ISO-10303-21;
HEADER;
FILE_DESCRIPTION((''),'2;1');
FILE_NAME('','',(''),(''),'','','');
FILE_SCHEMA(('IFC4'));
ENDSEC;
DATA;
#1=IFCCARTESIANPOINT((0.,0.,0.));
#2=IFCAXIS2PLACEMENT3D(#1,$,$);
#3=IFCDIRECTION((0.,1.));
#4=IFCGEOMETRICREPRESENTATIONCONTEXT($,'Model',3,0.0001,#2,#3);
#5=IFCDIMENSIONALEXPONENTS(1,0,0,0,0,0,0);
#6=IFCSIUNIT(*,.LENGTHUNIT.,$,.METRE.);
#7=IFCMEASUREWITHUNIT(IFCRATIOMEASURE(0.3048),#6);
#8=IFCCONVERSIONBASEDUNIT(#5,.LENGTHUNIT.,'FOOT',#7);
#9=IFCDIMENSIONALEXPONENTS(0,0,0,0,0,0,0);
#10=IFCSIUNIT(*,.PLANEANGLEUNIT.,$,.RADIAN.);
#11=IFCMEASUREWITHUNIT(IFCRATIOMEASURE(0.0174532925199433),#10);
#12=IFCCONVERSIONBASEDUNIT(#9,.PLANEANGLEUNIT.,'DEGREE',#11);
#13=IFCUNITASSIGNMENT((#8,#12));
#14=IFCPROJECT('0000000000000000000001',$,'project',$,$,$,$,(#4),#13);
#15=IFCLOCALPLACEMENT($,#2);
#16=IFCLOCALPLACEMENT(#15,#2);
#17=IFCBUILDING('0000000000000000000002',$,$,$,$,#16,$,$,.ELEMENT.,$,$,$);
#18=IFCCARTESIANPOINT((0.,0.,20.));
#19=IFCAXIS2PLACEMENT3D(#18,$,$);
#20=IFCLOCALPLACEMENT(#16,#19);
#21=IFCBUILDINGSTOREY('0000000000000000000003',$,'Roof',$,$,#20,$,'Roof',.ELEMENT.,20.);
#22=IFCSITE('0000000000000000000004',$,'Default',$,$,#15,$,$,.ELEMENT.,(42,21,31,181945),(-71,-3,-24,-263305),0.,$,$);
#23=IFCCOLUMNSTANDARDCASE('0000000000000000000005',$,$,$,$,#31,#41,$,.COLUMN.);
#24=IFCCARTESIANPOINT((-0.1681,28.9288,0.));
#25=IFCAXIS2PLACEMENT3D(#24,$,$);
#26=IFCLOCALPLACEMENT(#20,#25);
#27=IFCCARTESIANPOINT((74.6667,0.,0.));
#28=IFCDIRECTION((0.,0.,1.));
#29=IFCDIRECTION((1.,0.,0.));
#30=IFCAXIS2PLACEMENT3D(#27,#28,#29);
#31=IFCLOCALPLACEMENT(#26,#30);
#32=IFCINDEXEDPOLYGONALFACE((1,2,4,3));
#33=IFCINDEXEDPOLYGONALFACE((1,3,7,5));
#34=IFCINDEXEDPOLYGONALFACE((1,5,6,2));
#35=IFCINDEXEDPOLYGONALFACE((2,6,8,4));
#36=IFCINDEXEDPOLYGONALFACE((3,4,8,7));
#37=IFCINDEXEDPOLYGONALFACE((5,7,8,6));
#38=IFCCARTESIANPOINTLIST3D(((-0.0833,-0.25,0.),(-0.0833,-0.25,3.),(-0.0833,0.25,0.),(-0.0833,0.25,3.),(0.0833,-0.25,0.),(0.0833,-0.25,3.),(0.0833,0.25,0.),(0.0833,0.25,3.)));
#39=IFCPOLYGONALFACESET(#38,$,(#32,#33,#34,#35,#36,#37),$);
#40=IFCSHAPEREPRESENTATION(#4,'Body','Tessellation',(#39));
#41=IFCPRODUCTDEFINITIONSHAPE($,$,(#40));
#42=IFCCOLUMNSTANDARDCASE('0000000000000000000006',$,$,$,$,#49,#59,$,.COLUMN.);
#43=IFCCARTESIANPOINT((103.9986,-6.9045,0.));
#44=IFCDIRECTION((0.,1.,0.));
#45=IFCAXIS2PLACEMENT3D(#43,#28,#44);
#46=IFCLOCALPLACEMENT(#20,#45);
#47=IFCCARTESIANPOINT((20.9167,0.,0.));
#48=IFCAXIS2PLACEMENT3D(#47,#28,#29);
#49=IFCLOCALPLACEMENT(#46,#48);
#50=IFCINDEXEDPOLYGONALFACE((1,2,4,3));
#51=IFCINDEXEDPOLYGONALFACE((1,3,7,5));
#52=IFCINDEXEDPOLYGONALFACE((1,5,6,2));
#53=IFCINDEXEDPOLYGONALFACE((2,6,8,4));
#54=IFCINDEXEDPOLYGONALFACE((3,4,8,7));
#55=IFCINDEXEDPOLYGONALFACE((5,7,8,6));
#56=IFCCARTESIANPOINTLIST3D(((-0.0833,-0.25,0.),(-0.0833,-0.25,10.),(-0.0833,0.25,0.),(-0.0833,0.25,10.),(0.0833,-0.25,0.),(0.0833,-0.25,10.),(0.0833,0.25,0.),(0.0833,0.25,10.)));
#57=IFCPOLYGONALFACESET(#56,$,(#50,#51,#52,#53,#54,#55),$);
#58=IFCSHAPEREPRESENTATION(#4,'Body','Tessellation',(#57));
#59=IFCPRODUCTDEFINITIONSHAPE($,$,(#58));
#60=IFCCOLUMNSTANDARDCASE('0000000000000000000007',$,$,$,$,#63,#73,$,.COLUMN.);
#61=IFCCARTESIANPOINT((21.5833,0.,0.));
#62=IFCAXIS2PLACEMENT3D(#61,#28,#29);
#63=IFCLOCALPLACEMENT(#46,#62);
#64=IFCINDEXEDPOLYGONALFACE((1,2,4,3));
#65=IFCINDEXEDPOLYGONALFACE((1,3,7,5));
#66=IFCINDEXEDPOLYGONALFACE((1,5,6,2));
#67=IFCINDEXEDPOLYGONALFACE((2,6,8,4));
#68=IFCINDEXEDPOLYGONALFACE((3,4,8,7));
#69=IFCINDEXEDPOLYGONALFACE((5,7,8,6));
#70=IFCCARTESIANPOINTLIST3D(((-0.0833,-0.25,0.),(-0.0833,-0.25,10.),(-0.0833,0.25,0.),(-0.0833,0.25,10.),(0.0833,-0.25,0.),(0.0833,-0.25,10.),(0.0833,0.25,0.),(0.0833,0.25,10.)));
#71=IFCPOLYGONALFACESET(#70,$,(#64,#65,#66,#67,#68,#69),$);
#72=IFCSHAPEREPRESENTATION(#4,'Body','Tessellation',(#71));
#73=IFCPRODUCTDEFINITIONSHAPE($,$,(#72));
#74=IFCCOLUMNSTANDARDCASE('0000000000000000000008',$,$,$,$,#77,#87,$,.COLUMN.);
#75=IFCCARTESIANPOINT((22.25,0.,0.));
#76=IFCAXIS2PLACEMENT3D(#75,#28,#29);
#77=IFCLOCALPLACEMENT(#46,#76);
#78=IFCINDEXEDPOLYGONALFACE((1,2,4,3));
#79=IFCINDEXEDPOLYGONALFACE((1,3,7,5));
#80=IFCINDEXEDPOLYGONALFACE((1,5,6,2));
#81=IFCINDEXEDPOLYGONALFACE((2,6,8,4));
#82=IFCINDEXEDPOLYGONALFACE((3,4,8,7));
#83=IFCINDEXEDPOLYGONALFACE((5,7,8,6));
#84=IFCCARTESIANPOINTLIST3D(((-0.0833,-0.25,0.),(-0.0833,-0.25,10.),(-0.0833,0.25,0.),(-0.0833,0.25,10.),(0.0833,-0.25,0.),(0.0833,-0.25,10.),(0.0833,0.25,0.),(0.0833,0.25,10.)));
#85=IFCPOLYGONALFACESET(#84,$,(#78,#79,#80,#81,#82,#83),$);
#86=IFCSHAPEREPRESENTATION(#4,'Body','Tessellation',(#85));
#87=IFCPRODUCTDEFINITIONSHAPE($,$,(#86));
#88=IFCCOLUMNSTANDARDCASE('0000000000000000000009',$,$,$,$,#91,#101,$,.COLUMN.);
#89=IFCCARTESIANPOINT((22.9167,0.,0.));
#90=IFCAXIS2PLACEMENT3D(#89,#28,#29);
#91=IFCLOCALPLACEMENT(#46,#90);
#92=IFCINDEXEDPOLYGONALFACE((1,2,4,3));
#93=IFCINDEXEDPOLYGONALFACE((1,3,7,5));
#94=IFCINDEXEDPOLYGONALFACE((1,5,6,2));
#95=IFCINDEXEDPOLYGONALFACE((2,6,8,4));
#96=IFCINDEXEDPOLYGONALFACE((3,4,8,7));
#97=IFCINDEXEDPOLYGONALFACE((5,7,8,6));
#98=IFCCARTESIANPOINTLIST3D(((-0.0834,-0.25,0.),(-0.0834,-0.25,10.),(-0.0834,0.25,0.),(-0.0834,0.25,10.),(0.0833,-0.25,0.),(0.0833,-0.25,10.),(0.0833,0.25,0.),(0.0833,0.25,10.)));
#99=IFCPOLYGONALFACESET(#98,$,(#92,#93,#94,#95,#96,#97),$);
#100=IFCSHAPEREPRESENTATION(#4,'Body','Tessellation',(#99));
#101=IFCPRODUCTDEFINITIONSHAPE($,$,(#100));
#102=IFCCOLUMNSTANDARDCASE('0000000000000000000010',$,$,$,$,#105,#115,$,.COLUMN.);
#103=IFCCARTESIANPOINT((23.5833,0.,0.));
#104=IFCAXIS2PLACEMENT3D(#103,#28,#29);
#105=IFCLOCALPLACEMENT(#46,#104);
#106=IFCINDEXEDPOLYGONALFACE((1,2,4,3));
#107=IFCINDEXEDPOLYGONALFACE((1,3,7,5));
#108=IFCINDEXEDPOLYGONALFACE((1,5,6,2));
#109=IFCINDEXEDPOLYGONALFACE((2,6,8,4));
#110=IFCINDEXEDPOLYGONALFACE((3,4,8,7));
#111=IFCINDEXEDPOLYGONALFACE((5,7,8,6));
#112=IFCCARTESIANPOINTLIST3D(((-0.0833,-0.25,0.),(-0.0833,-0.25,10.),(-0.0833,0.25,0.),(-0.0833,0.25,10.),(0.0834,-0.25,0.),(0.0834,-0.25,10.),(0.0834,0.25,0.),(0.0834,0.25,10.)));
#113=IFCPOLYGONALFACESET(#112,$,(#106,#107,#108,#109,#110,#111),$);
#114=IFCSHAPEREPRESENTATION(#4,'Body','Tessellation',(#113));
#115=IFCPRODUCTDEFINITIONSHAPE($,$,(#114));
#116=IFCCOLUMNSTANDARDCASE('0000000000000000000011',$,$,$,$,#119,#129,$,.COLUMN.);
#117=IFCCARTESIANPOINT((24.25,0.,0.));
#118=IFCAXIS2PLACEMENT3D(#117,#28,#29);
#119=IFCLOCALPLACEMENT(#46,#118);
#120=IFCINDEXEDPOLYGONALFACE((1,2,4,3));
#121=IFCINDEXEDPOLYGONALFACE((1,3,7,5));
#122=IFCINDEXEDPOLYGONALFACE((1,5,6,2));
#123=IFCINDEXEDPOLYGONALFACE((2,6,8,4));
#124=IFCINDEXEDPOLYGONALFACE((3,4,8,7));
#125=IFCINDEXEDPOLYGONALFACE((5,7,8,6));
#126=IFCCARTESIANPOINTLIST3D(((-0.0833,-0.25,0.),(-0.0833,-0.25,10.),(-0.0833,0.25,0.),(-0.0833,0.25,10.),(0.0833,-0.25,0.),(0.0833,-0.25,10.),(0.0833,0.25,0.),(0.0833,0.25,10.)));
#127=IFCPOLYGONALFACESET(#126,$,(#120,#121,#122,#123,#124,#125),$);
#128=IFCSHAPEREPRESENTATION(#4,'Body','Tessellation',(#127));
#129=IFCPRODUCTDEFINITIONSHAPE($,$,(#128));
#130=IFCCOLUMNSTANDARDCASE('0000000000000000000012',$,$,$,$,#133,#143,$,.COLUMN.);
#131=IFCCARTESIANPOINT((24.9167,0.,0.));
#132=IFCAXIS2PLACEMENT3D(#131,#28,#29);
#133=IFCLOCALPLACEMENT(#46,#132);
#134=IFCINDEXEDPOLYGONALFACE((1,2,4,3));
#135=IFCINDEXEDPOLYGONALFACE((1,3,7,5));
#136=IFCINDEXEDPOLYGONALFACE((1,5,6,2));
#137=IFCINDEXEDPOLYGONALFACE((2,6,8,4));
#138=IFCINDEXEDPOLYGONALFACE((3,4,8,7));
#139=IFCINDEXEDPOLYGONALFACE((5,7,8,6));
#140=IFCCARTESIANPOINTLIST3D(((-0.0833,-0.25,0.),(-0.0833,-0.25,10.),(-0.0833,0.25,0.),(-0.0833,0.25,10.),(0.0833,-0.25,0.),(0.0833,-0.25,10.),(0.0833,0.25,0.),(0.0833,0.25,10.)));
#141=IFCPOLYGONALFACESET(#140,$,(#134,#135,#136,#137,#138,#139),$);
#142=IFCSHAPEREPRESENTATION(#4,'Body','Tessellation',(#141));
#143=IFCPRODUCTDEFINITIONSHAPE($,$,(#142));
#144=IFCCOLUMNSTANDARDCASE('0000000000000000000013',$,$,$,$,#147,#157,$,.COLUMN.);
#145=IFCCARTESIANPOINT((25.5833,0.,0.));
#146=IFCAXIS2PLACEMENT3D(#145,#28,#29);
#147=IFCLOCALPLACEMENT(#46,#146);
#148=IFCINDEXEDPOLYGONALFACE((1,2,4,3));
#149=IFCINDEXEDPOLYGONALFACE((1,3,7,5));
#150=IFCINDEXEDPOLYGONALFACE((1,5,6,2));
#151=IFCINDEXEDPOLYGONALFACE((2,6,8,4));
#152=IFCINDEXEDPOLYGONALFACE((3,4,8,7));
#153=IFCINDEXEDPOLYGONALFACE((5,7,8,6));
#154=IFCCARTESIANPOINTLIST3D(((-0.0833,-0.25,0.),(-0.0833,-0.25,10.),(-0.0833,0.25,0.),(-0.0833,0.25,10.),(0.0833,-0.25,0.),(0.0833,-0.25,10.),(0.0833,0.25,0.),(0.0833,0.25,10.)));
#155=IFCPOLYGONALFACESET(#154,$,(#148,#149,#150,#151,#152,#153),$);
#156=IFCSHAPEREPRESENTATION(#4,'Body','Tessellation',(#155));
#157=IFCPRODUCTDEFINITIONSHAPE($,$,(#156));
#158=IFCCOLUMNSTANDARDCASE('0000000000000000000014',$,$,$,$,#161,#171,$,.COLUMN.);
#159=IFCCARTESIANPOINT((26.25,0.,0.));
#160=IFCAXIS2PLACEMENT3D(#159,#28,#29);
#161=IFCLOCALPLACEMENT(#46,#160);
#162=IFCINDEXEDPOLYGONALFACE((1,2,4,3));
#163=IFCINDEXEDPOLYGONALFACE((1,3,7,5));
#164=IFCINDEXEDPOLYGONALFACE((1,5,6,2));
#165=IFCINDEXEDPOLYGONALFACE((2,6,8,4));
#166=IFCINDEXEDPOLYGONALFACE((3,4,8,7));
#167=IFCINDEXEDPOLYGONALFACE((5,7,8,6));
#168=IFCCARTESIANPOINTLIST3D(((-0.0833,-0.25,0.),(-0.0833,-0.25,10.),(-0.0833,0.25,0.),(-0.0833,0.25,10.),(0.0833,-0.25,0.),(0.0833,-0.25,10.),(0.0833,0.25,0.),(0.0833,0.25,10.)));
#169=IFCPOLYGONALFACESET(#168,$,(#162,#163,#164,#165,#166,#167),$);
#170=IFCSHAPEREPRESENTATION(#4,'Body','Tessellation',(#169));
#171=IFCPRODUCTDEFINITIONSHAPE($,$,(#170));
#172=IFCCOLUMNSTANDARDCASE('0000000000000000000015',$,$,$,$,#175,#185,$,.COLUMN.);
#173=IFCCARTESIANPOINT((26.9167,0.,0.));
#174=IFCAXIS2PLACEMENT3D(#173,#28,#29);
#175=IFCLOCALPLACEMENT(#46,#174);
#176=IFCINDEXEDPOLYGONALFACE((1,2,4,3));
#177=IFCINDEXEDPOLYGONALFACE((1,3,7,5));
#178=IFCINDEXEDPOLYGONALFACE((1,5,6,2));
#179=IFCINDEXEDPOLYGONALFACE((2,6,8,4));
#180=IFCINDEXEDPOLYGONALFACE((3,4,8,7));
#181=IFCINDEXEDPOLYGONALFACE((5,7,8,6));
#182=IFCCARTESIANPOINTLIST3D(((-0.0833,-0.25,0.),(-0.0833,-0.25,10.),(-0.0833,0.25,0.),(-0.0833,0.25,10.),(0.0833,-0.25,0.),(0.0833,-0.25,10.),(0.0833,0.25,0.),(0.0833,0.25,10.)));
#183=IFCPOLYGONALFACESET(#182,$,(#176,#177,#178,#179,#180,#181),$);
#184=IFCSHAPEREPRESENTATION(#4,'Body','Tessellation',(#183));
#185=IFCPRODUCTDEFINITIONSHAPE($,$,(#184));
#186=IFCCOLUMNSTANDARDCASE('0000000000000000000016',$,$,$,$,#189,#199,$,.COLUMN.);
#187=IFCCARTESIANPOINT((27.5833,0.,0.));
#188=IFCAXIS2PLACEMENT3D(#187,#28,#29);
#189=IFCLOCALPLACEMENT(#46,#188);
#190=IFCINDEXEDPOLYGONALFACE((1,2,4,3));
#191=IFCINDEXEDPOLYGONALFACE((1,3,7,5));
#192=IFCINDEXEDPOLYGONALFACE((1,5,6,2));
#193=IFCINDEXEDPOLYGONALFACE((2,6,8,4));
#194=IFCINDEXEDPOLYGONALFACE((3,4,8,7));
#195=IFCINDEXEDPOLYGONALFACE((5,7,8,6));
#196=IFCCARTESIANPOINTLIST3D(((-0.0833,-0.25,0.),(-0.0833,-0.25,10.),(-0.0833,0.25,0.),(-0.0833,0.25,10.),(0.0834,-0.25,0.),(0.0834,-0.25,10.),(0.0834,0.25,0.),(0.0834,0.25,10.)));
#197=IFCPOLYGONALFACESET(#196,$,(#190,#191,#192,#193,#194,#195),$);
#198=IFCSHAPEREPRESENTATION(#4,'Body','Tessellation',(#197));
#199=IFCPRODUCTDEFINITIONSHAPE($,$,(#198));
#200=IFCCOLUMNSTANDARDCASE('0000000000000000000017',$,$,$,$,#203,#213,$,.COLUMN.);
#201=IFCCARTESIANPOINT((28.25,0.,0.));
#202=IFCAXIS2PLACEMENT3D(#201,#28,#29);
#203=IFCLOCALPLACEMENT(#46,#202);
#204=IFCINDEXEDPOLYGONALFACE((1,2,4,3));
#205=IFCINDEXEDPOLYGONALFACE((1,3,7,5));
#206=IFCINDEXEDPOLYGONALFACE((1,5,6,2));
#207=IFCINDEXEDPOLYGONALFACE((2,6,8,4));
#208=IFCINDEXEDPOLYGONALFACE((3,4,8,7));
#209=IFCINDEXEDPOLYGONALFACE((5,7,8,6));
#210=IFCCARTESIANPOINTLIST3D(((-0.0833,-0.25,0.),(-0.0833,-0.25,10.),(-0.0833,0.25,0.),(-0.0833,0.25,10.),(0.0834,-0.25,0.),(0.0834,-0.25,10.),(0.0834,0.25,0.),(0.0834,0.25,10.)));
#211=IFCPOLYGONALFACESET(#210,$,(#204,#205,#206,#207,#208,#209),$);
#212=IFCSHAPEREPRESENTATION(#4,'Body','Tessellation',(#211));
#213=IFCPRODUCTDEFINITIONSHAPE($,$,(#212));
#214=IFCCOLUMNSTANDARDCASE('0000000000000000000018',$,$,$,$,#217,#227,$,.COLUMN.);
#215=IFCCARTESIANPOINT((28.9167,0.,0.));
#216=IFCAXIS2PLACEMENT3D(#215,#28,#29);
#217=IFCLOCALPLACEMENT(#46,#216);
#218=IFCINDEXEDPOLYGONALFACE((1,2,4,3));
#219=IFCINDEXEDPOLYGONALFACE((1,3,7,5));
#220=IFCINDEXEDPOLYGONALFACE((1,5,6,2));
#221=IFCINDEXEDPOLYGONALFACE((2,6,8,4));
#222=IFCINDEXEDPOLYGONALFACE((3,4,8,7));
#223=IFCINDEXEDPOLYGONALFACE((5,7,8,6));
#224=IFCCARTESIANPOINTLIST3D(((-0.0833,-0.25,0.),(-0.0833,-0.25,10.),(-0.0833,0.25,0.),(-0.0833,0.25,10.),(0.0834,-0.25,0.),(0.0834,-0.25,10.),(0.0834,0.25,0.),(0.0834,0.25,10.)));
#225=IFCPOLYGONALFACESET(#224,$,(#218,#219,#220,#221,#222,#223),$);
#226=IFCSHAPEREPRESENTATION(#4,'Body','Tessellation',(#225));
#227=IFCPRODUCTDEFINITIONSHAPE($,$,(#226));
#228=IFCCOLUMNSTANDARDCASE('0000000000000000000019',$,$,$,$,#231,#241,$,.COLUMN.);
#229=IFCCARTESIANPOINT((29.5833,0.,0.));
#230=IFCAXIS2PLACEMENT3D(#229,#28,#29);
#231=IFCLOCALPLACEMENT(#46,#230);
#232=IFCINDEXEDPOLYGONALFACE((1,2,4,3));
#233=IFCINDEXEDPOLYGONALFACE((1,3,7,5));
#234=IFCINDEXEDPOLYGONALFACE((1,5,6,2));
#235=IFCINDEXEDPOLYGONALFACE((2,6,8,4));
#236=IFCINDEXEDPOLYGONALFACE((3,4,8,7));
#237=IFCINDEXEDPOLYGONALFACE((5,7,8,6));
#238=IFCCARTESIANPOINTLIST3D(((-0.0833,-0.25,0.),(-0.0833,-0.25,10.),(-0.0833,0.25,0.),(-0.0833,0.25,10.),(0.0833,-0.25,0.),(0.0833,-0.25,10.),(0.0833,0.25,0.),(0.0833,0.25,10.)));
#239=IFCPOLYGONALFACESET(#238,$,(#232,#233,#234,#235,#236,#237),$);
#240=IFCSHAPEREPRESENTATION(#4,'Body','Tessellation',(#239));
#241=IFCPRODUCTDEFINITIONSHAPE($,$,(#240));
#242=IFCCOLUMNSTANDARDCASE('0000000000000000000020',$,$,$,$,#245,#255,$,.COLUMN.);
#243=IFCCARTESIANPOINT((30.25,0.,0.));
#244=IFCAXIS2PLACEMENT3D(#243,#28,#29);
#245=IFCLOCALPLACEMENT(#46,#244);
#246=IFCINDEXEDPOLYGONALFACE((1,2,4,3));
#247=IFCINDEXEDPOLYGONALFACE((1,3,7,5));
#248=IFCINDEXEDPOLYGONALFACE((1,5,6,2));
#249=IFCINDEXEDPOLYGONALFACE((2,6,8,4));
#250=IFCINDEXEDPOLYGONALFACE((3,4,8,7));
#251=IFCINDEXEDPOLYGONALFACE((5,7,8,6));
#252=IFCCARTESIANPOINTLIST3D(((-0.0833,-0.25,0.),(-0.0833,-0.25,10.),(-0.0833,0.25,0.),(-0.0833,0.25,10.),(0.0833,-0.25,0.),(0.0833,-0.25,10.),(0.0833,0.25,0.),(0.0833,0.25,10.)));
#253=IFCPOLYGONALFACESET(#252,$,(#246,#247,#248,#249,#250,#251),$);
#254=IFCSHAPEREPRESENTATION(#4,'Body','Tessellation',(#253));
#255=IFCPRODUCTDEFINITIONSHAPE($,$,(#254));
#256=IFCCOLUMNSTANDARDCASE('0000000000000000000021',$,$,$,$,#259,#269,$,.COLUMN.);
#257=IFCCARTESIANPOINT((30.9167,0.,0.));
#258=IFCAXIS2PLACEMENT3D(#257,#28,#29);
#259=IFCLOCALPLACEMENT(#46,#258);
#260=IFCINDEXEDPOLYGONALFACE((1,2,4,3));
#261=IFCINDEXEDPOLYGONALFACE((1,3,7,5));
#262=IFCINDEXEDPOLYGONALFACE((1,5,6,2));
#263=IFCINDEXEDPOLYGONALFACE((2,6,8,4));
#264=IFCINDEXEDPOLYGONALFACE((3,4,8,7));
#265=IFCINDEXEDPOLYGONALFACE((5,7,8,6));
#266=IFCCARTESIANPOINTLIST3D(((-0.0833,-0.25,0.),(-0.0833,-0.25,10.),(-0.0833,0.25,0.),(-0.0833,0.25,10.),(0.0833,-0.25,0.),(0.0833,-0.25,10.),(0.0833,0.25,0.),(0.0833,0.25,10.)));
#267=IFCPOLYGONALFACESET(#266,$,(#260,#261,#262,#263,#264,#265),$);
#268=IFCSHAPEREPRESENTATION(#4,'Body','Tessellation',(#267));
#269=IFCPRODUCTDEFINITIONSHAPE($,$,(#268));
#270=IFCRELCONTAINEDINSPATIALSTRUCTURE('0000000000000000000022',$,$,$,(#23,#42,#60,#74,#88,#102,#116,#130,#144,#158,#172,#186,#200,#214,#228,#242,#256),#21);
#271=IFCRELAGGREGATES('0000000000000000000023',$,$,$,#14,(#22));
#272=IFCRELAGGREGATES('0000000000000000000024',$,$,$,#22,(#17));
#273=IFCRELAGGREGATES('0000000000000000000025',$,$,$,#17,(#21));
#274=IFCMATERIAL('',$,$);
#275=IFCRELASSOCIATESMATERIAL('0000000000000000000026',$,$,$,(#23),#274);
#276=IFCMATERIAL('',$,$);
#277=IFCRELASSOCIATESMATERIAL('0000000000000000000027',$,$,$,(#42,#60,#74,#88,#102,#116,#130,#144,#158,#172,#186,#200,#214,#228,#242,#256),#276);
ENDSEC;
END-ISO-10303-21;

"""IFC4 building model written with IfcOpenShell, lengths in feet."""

from ifc_helpers import new_model, entity, si_unit, converted_unit, direction, frame, origin, place, context, project, spatial, rectangle, extrude, material, element, save


model = new_model("IFC4")

# Units and contexts
model_context = context("Model", 3, precision=0.0001, world=origin(), true_north=direction((0.0, 1.0)))
ifc_project = project(units=[converted_unit("LENGTHUNIT", "FOOT", entity("IfcRatioMeasure", 0.3048), si_unit("LENGTHUNIT", "METRE"), dimensions=[1, 0, 0, 0, 0, 0, 0]), converted_unit("PLANEANGLEUNIT", "DEGREE", entity("IfcRatioMeasure", 0.0174532925199433), si_unit("PLANEANGLEUNIT", "RADIAN"), dimensions=[0, 0, 0, 0, 0, 0, 0])], contexts=[model_context])

# Site, building, storey
site_placement = place(None, origin())
site = spatial("IfcSite", under=ifc_project, at=site_placement, Name="Default", CompositionType="ELEMENT", RefLatitude=(42, 21, 31, 181945), RefLongitude=(-71, -3, -24, -263305), RefElevation=0.0)
building_placement = place(site_placement, origin())
building = spatial("IfcBuilding", under=site, at=building_placement, CompositionType="ELEMENT")
storey_placement = place(building_placement, frame((0.0, 0.0, 20.0)))
storey = spatial("IfcBuildingStorey", under=building, at=storey_placement, Name="Roof", LongName="Roof", CompositionType="ELEMENT", Elevation=20.0)

# Columns
ifc_material_1 = material(Name="")
placement_1 = place(storey_placement, frame((-0.1681, 28.9288, 0.0)))
for number, where, z_axis, x_axis in (
    (1, (74.6667, 0.0, 0.0), (0.0, 0.0, 1.0), (1.0, 0.0, 0.0)),
):
    element("IfcColumnStandardCase", number, at=place(placement_1, frame(where, z_axis=z_axis, x_axis=x_axis)), inside=storey, material=ifc_material_1, PredefinedType="COLUMN", context=model_context, shape_type="SweptSolid", body=[
        extrude(rectangle(XDim=0.1667, YDim=0.5), origin(), (0.0, 0.0, 1.0), 3.0),
    ])
ifc_material_2 = material(Name="")
placement_2 = place(storey_placement, frame((103.9986, -6.9045, 0.0), z_axis=(0.0, 0.0, 1.0), x_axis=(0.0, 1.0, 0.0)))
for number, where, z_axis, x_axis in (
    (2, (20.9167, 0.0, 0.0), (0.0, 0.0, 1.0), (1.0, 0.0, 0.0)),
    (3, (21.5833, 0.0, 0.0), (0.0, 0.0, 1.0), (1.0, 0.0, 0.0)),
    (4, (22.25, 0.0, 0.0), (0.0, 0.0, 1.0), (1.0, 0.0, 0.0)),
    (5, (22.9167, 0.0, 0.0), (0.0, 0.0, 1.0), (1.0, 0.0, 0.0)),
    (6, (23.5833, 0.0, 0.0), (0.0, 0.0, 1.0), (1.0, 0.0, 0.0)),
    (7, (24.25, 0.0, 0.0), (0.0, 0.0, 1.0), (1.0, 0.0, 0.0)),
    (8, (24.9167, 0.0, 0.0), (0.0, 0.0, 1.0), (1.0, 0.0, 0.0)),
    (9, (25.5833, 0.0, 0.0), (0.0, 0.0, 1.0), (1.0, 0.0, 0.0)),
    (10, (26.25, 0.0, 0.0), (0.0, 0.0, 1.0), (1.0, 0.0, 0.0)),
    (11, (26.9167, 0.0, 0.0), (0.0, 0.0, 1.0), (1.0, 0.0, 0.0)),
    (12, (27.5833, 0.0, 0.0), (0.0, 0.0, 1.0), (1.0, 0.0, 0.0)),
    (13, (28.25, 0.0, 0.0), (0.0, 0.0, 1.0), (1.0, 0.0, 0.0)),
    (14, (28.9167, 0.0, 0.0), (0.0, 0.0, 1.0), (1.0, 0.0, 0.0)),
    (15, (29.5833, 0.0, 0.0), (0.0, 0.0, 1.0), (1.0, 0.0, 0.0)),
    (16, (30.25, 0.0, 0.0), (0.0, 0.0, 1.0), (1.0, 0.0, 0.0)),
    (17, (30.9167, 0.0, 0.0), (0.0, 0.0, 1.0), (1.0, 0.0, 0.0)),
):
    element("IfcColumnStandardCase", number, at=place(placement_2, frame(where, z_axis=z_axis, x_axis=x_axis)), inside=storey, material=ifc_material_2, PredefinedType="COLUMN", context=model_context, shape_type="SweptSolid", body=[
        extrude(rectangle(XDim=0.1667, YDim=0.5), origin(), (0.0, 0.0, 1.0), 10.0),
    ])

save(model, "model.ifc")
